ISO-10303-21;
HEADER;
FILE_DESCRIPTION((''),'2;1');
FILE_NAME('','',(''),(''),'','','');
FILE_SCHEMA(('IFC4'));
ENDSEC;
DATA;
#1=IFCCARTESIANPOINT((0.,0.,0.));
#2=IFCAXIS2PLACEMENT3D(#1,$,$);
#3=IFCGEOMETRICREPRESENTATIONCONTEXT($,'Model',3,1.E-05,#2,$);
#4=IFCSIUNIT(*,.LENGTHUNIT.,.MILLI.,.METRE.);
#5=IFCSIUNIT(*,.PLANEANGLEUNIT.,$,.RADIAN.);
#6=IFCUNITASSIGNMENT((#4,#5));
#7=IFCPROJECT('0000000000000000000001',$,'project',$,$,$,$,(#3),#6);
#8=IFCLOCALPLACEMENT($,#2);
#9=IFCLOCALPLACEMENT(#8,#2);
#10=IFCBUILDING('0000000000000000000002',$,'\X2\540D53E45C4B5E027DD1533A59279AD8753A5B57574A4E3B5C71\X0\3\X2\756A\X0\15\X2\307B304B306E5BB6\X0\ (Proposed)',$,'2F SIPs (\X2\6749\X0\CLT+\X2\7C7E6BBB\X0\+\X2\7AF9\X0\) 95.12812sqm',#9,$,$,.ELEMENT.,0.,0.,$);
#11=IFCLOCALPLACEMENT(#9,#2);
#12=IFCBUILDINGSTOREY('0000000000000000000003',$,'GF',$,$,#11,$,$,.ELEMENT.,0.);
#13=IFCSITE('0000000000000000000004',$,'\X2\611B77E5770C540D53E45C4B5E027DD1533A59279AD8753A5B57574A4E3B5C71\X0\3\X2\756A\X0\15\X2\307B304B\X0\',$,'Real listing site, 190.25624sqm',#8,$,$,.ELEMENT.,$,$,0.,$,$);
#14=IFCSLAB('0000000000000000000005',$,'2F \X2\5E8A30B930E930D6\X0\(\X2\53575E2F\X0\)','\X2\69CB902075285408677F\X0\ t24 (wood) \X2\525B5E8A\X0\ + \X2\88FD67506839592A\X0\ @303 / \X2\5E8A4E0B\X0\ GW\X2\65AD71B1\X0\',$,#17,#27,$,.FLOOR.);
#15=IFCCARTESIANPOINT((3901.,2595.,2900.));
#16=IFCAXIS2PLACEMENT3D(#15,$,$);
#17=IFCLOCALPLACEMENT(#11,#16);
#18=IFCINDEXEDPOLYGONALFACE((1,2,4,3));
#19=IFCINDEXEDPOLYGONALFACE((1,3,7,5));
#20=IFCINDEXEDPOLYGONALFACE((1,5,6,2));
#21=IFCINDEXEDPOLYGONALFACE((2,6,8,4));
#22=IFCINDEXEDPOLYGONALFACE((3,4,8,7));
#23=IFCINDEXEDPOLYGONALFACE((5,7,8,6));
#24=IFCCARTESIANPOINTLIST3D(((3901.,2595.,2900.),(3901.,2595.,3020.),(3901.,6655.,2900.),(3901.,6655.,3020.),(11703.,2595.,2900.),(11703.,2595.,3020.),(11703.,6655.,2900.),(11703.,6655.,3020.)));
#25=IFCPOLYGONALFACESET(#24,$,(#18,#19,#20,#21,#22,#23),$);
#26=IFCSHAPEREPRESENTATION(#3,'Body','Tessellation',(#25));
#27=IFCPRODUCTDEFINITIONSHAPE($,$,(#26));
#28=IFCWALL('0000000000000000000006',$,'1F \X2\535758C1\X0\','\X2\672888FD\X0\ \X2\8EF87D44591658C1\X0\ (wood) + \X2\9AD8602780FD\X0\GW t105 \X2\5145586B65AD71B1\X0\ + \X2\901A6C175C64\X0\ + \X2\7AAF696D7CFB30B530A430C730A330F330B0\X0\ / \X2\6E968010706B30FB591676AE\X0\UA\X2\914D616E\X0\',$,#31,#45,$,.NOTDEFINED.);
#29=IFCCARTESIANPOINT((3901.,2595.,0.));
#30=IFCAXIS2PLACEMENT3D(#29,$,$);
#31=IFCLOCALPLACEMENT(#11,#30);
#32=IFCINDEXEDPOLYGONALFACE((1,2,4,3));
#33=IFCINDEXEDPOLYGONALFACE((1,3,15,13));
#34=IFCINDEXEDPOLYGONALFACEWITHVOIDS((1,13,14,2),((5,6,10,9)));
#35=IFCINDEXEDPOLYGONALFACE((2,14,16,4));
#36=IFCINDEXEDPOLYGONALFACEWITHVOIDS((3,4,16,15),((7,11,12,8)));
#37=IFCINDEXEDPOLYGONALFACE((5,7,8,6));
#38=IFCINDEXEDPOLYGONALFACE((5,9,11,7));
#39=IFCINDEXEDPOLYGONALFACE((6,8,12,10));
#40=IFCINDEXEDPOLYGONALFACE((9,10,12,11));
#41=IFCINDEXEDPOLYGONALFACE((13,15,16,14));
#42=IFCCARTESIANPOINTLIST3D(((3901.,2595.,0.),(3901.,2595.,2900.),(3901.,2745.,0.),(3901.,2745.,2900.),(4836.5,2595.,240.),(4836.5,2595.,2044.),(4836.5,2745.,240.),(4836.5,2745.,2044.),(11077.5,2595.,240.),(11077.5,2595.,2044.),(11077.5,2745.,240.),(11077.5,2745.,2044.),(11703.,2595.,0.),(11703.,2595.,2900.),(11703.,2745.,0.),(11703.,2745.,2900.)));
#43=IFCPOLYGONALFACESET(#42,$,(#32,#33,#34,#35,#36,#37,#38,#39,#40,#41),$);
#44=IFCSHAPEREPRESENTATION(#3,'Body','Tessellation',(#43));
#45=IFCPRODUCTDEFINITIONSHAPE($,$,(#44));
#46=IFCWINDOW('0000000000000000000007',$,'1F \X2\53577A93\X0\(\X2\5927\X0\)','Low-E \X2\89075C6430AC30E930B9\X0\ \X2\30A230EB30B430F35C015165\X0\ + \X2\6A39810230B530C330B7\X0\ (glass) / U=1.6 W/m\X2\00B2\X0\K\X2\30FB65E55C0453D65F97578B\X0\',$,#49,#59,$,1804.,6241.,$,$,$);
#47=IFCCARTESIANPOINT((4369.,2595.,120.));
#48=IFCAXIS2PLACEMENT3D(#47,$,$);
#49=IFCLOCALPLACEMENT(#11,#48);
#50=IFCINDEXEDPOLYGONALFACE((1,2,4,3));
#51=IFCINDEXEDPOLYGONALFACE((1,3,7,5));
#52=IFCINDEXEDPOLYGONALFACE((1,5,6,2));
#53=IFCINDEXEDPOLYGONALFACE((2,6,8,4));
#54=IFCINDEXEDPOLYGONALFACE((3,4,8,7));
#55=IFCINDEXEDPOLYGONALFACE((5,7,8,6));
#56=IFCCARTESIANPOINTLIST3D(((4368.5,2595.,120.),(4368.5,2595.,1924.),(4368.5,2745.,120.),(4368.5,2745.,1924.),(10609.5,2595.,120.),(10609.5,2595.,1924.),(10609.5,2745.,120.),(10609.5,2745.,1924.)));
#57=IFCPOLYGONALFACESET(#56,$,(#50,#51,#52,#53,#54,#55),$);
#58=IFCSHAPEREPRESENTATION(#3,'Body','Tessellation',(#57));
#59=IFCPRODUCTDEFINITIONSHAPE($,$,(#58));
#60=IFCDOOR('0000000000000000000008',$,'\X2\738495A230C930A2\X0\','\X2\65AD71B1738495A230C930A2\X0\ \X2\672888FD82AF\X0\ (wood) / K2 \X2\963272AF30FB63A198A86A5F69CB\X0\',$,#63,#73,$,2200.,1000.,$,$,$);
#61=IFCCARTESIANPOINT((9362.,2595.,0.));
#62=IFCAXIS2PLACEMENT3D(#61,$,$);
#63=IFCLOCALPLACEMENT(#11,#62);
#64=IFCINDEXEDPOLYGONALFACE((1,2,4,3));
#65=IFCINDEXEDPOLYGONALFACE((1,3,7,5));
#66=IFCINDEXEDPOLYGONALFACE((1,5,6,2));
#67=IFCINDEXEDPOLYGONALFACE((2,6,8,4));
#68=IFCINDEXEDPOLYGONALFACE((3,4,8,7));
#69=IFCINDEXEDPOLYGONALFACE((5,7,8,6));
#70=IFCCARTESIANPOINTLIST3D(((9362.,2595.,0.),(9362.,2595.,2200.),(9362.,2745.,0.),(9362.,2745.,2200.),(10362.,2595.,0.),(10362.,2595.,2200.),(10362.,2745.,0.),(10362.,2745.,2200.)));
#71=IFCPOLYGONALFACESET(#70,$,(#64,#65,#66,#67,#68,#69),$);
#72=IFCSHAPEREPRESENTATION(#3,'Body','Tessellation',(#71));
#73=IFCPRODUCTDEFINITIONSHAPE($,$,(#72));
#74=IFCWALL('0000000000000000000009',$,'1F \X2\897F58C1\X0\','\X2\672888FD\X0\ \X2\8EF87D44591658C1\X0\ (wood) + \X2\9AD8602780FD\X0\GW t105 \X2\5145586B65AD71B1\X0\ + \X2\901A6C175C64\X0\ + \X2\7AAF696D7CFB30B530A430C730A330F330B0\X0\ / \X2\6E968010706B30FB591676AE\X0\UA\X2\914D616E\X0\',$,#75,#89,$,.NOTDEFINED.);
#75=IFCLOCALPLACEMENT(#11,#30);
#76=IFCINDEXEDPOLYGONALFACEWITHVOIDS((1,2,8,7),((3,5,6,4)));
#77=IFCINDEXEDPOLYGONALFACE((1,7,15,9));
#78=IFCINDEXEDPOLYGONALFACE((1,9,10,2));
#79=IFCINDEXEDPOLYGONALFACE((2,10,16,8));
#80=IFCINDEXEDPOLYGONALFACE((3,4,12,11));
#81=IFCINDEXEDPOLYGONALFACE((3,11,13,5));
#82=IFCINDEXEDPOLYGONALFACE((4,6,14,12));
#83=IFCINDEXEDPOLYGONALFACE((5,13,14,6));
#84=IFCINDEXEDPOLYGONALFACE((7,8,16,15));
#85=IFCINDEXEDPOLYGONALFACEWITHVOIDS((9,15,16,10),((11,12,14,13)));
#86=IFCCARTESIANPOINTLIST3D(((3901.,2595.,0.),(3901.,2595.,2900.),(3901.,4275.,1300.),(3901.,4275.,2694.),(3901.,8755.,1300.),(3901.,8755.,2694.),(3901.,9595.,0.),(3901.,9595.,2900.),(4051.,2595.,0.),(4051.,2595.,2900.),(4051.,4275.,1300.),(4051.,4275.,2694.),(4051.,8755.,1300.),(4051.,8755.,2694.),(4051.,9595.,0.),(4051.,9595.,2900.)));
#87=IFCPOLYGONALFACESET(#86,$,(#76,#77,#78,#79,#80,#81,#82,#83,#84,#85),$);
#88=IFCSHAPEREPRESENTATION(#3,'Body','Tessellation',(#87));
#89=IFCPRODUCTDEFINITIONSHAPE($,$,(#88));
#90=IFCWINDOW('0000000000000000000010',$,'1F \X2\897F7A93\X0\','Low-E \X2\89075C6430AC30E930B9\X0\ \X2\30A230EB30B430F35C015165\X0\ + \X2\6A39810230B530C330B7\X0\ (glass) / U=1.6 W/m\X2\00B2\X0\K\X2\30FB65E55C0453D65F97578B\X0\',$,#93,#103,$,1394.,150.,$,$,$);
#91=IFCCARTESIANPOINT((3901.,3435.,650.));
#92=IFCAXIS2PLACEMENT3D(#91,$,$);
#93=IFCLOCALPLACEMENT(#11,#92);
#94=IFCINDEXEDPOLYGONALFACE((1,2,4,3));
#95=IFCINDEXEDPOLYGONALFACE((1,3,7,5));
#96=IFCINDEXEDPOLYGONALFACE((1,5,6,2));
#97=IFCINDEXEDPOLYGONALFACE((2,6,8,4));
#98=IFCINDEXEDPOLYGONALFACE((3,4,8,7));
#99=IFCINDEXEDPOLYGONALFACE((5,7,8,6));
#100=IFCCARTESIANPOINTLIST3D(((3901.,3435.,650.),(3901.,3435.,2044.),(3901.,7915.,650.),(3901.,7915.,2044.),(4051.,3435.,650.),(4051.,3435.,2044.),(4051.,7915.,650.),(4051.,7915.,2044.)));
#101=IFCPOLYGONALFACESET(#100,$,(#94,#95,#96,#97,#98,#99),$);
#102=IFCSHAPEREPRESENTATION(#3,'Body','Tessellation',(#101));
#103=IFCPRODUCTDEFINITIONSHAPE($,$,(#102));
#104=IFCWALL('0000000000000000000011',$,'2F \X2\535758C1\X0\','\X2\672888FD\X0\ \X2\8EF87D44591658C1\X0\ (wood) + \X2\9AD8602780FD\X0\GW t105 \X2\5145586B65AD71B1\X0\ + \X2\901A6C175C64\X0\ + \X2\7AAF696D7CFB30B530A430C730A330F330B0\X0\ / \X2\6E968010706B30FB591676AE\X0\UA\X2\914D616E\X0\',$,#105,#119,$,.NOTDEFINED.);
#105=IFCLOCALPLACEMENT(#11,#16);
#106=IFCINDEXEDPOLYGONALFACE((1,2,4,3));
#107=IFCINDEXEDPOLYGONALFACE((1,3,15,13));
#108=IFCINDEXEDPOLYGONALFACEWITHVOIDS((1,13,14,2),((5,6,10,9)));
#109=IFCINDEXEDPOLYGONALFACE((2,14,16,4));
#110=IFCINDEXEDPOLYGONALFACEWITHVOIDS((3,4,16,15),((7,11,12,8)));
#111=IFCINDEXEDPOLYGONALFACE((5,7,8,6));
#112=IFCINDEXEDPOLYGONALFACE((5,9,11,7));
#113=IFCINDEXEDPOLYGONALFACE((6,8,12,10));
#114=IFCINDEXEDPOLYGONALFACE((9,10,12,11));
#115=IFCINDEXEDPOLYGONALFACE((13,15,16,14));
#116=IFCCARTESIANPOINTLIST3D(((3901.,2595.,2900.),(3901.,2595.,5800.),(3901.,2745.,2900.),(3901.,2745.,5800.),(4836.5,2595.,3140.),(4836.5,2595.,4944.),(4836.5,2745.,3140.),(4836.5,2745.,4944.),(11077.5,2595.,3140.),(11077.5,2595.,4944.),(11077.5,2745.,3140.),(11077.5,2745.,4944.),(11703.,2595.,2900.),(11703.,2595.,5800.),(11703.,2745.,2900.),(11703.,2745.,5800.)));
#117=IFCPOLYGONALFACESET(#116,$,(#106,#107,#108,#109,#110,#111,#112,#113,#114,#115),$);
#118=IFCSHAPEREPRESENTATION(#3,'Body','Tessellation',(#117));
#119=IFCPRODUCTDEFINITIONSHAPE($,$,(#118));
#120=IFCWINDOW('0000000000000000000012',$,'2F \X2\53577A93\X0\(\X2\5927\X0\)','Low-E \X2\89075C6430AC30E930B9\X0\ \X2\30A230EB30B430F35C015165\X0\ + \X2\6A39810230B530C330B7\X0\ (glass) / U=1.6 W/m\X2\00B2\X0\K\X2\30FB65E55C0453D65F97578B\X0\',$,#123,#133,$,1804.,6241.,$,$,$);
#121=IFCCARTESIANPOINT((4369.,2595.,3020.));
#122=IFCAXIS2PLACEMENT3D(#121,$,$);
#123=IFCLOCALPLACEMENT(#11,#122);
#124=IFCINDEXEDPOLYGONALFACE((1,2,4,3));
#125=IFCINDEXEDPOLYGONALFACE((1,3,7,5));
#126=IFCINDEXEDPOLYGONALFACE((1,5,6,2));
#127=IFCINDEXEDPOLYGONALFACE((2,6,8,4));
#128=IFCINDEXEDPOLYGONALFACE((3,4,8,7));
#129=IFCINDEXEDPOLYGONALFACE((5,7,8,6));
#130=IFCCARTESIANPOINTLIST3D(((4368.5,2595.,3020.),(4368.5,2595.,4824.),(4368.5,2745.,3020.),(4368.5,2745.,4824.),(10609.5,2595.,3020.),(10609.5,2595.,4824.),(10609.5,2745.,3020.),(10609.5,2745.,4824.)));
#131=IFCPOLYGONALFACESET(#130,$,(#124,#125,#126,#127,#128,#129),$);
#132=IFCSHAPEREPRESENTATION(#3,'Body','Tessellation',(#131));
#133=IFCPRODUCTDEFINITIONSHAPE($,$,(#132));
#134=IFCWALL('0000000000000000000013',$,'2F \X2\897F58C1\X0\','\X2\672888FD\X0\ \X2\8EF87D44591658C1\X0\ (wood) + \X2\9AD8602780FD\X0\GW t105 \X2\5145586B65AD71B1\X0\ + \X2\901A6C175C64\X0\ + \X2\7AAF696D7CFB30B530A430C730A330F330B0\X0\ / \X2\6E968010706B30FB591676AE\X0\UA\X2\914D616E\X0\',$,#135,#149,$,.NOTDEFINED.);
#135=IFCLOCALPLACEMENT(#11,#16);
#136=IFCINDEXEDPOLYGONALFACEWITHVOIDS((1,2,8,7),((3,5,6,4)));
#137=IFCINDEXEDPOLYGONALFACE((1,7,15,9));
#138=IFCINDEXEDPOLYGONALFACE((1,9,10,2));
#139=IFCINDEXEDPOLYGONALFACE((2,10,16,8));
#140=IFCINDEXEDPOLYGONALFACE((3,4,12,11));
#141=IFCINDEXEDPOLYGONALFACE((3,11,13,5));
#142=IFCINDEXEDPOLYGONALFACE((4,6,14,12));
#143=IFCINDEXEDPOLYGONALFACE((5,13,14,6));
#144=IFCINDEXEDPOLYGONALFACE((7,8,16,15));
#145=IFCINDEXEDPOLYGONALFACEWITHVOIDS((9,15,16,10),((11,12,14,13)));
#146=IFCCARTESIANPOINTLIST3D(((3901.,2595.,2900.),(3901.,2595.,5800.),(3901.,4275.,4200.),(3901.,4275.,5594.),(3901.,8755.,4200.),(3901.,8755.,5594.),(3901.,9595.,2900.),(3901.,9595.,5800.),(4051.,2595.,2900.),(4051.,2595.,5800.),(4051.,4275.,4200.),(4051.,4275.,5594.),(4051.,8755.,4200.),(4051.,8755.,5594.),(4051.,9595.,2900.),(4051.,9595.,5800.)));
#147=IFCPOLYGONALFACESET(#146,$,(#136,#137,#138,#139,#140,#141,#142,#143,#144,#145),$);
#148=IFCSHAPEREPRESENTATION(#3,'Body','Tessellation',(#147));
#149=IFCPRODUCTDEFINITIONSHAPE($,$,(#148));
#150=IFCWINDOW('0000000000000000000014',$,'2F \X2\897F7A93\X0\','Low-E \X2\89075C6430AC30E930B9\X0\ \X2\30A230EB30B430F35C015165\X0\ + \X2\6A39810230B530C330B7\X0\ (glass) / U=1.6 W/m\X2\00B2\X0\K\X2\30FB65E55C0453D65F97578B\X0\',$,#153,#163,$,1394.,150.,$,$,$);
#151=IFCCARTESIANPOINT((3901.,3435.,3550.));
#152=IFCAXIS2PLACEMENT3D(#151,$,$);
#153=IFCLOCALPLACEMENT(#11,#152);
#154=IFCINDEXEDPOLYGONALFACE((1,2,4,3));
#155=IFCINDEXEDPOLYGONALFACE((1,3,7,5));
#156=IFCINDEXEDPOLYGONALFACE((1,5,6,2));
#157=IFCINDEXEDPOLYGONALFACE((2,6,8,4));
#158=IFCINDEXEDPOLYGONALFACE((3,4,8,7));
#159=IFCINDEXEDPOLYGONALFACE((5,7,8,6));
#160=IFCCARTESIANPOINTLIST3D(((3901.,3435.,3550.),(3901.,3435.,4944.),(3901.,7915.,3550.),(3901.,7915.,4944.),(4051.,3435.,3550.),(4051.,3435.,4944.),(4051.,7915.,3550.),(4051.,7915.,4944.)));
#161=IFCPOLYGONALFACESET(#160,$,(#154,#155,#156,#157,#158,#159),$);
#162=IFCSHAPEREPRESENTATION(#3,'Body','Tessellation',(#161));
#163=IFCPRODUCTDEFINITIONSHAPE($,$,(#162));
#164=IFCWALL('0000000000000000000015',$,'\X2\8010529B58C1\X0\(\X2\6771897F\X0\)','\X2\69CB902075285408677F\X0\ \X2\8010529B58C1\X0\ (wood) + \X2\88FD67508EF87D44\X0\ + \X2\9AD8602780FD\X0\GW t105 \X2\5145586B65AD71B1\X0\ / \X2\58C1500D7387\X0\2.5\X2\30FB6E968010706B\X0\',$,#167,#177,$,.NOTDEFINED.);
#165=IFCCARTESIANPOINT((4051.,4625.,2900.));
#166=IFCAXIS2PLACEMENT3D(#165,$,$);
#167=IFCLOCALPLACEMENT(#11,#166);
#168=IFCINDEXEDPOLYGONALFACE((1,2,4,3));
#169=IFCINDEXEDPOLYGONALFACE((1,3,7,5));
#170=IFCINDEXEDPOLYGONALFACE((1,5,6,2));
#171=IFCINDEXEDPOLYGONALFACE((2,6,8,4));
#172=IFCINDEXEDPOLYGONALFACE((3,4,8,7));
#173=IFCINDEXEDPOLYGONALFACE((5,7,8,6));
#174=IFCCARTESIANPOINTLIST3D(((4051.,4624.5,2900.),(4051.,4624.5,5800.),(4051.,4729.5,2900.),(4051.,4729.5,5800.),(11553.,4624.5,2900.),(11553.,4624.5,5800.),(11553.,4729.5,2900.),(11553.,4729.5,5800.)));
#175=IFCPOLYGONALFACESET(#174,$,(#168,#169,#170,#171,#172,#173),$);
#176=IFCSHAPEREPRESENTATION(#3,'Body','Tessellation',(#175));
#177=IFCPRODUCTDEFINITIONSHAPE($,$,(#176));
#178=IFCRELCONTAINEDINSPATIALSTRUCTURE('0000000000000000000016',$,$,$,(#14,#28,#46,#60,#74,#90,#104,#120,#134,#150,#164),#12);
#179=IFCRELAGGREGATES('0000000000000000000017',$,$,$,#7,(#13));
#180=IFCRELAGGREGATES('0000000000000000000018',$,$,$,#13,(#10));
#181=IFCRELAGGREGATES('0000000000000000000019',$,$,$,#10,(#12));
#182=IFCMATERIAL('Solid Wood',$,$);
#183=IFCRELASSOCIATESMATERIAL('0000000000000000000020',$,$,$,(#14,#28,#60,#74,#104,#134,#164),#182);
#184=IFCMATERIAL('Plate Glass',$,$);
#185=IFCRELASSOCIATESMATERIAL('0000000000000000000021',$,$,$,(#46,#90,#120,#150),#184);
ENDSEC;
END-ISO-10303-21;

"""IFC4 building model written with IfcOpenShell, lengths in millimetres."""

from ifc_helpers import new_model, si_unit, frame, frame_2d, origin, place, context, project, spatial, rectangle, extrude, material, element, fill, save


model = new_model("IFC4")

# Units and contexts
model_context = context("Model", 3, precision=1e-05, world=origin())
ifc_project = project(units=[si_unit("LENGTHUNIT", "METRE", prefix="MILLI"), si_unit("PLANEANGLEUNIT", "RADIAN")], contexts=[model_context])

# Site, building, storey
site_placement = place(None, origin())
site = spatial("IfcSite", under=ifc_project, at=site_placement, Name="愛知県名古屋市緑区大高町字坊主山3番15ほか", ObjectType="Real listing site, 190.25624sqm", CompositionType="ELEMENT", RefElevation=0.0)
building_placement = place(site_placement, origin())
building = spatial("IfcBuilding", under=site, at=building_placement, Name="名古屋市緑区大高町字坊主山3番15ほかの家 (Proposed)", ObjectType="2F SIPs (杉CLT+籾殻+竹) 95.12812sqm", CompositionType="ELEMENT", ElevationOfRefHeight=0.0, ElevationOfTerrain=0.0)
storey_placement = place(building_placement, origin())
storey = spatial("IfcBuildingStorey", under=building, at=storey_placement, Name="GF", CompositionType="ELEMENT", Elevation=0.0)

# Slab
ifc_material_1 = material(Name="Solid Wood")
slab_1_placement = place(storey_placement, frame((3901.0, 2595.0, 2900.0)))
element("IfcSlab", 1, at=slab_1_placement, inside=storey, material=ifc_material_1, Name="2F 床スラブ(南帯)", Description="構造用合板 t24 (wood) 剛床 + 製材根太 @303 / 床下 GW断熱", PredefinedType="FLOOR", context=model_context, shape_type="SweptSolid", body=[
    extrude(rectangle(XDim=7802.0, YDim=4060.0, at=frame_2d((3901.0, 2030.0))), frame((3901.0, 2595.0, 2900.0)), (0.0, 0.0, 1.0), 120.0),
])

# Wall, openings, window, door
wall_1_placement = place(storey_placement, frame((3901.0, 2595.0, 0.0)))
wall_1 = element("IfcWall", 2, at=wall_1_placement, inside=storey, material=ifc_material_1, Name="1F 南壁", Description="木製 軸組外壁 (wood) + 高性能GW t105 充填断熱 + 通気層 + 窯業系サイディング / 準耐火・外皮UA配慮", PredefinedType="NOTDEFINED", context=model_context, shape_type="SweptSolid", body=[
    extrude(rectangle(XDim=7802.0, YDim=150.0, at=frame_2d((3901.0, 75.0))), frame((3901.0, 2595.0, 0.0)), (0.0, 0.0, 1.0), 2900.0),
])
opening_1_placement = place(storey_placement, frame((4369.0, 2595.0, 120.0)))
opening_1 = element("IfcOpeningElement", 3, at=opening_1_placement, cuts=wall_1, PredefinedType="NOTDEFINED", context=model_context, shape_type="SweptSolid", body=[
    extrude(rectangle(XDim=6241.0, YDim=150.0, at=frame_2d((3120.0, 75.0))), frame((4369.0, 2595.0, 120.0)), (0.0, 0.0, 1.0), 1804.0),
])
opening_2_placement = place(storey_placement, frame((9362.0, 2595.0, 0.0)))
opening_2 = element("IfcOpeningElement", 4, at=opening_2_placement, cuts=wall_1, PredefinedType="NOTDEFINED", context=model_context, shape_type="SweptSolid", body=[
    extrude(rectangle(XDim=1000.0, YDim=150.0, at=frame_2d((500.0, 75.0))), frame((9362.0, 2595.0, 0.0)), (0.0, 0.0, 1.0), 2200.0),
])
ifc_material_2 = material(Name="Plate Glass")
window_1_placement = place(storey_placement, frame((4369.0, 2595.0, 120.0)))
window_1 = element("IfcWindow", 5, at=window_1_placement, inside=storey, material=ifc_material_2, Name="1F 南窓(大)", Description="Low-E 複層ガラス アルゴン封入 + 樹脂サッシ (glass) / U=1.6 W/m²K・日射取得型", OverallHeight=1804.0, OverallWidth=6241.0, context=model_context, shape_type="SweptSolid", body=[
    extrude(rectangle(XDim=6241.0, YDim=150.0, at=frame_2d((3120.0, 75.0))), frame((4369.0, 2595.0, 120.0)), (0.0, 0.0, 1.0), 1804.0),
])
fill(opening_1, window_1)
door_placement = place(storey_placement, frame((9362.0, 2595.0, 0.0)))
door = element("IfcDoor", 6, at=door_placement, inside=storey, material=ifc_material_1, Name="玄関ドア", Description="断熱玄関ドア 木製芯 (wood) / K2 防犯・採風機構", OverallHeight=2200.0, OverallWidth=1000.0, context=model_context, shape_type="SweptSolid", body=[
    extrude(rectangle(XDim=1000.0, YDim=150.0, at=frame_2d((500.0, 75.0))), frame((9362.0, 2595.0, 0.0)), (0.0, 0.0, 1.0), 2200.0),
])
fill(opening_2, door)

# Wall, opening, window
wall_2_placement = place(storey_placement, frame((3901.0, 2595.0, 0.0)))
wall_2 = element("IfcWall", 7, at=wall_2_placement, inside=storey, material=ifc_material_1, Name="1F 西壁", Description="木製 軸組外壁 (wood) + 高性能GW t105 充填断熱 + 通気層 + 窯業系サイディング / 準耐火・外皮UA配慮", PredefinedType="NOTDEFINED", context=model_context, shape_type="SweptSolid", body=[
    extrude(rectangle(XDim=150.0, YDim=7000.0, at=frame_2d((75.0, 3500.0))), frame((3901.0, 2595.0, 0.0)), (0.0, 0.0, 1.0), 2900.0),
])
opening_3_placement = place(storey_placement, frame((3901.0, 3435.0, 650.0)))
opening_3 = element("IfcOpeningElement", 8, at=opening_3_placement, cuts=wall_2, PredefinedType="NOTDEFINED", context=model_context, shape_type="SweptSolid", body=[
    extrude(rectangle(XDim=150.0, YDim=4480.0, at=frame_2d((75.0, 2240.0))), frame((3901.0, 3435.0, 650.0)), (0.0, 0.0, 1.0), 1394.0),
])
window_2_placement = place(storey_placement, frame((3901.0, 3435.0, 650.0)))
window_2 = element("IfcWindow", 9, at=window_2_placement, inside=storey, material=ifc_material_2, Name="1F 西窓", Description="Low-E 複層ガラス アルゴン封入 + 樹脂サッシ (glass) / U=1.6 W/m²K・日射取得型", OverallHeight=1394.0, OverallWidth=150.0, context=model_context, shape_type="SweptSolid", body=[
    extrude(rectangle(XDim=150.0, YDim=4480.0, at=frame_2d((75.0, 2240.0))), frame((3901.0, 3435.0, 650.0)), (0.0, 0.0, 1.0), 1394.0),
])
fill(opening_3, window_2)

# Walls, openings, windows
wall_3_placement = place(storey_placement, frame((3901.0, 2595.0, 2900.0)))
wall_3 = element("IfcWall", 10, at=wall_3_placement, inside=storey, material=ifc_material_1, Name="2F 南壁", Description="木製 軸組外壁 (wood) + 高性能GW t105 充填断熱 + 通気層 + 窯業系サイディング / 準耐火・外皮UA配慮", PredefinedType="NOTDEFINED", context=model_context, shape_type="SweptSolid", body=[
    extrude(rectangle(XDim=7802.0, YDim=150.0, at=frame_2d((3901.0, 75.0))), frame((3901.0, 2595.0, 2900.0)), (0.0, 0.0, 1.0), 2900.0),
])
opening_4_placement = place(storey_placement, frame((4369.0, 2595.0, 3020.0)))
opening_4 = element("IfcOpeningElement", 11, at=opening_4_placement, cuts=wall_3, PredefinedType="NOTDEFINED", context=model_context, shape_type="SweptSolid", body=[
    extrude(rectangle(XDim=6241.0, YDim=150.0, at=frame_2d((3120.0, 75.0))), frame((4369.0, 2595.0, 3020.0)), (0.0, 0.0, 1.0), 1804.0),
])
window_3_placement = place(storey_placement, frame((4369.0, 2595.0, 3020.0)))
window_3 = element("IfcWindow", 12, at=window_3_placement, inside=storey, material=ifc_material_2, Name="2F 南窓(大)", Description="Low-E 複層ガラス アルゴン封入 + 樹脂サッシ (glass) / U=1.6 W/m²K・日射取得型", OverallHeight=1804.0, OverallWidth=6241.0, context=model_context, shape_type="SweptSolid", body=[
    extrude(rectangle(XDim=6241.0, YDim=150.0, at=frame_2d((3120.0, 75.0))), frame((4369.0, 2595.0, 3020.0)), (0.0, 0.0, 1.0), 1804.0),
])
fill(opening_4, window_3)
wall_4_placement = place(storey_placement, frame((3901.0, 2595.0, 2900.0)))
wall_4 = element("IfcWall", 13, at=wall_4_placement, inside=storey, material=ifc_material_1, Name="2F 西壁", Description="木製 軸組外壁 (wood) + 高性能GW t105 充填断熱 + 通気層 + 窯業系サイディング / 準耐火・外皮UA配慮", PredefinedType="NOTDEFINED", context=model_context, shape_type="SweptSolid", body=[
    extrude(rectangle(XDim=150.0, YDim=7000.0, at=frame_2d((75.0, 3500.0))), frame((3901.0, 2595.0, 2900.0)), (0.0, 0.0, 1.0), 2900.0),
])
opening_5_placement = place(storey_placement, frame((3901.0, 3435.0, 3550.0)))
opening_5 = element("IfcOpeningElement", 14, at=opening_5_placement, cuts=wall_4, PredefinedType="NOTDEFINED", context=model_context, shape_type="SweptSolid", body=[
    extrude(rectangle(XDim=150.0, YDim=4480.0, at=frame_2d((75.0, 2240.0))), frame((3901.0, 3435.0, 3550.0)), (0.0, 0.0, 1.0), 1394.0),
])
window_4_placement = place(storey_placement, frame((3901.0, 3435.0, 3550.0)))
window_4 = element("IfcWindow", 15, at=window_4_placement, inside=storey, material=ifc_material_2, Name="2F 西窓", Description="Low-E 複層ガラス アルゴン封入 + 樹脂サッシ (glass) / U=1.6 W/m²K・日射取得型", OverallHeight=1394.0, OverallWidth=150.0, context=model_context, shape_type="SweptSolid", body=[
    extrude(rectangle(XDim=150.0, YDim=4480.0, at=frame_2d((75.0, 2240.0))), frame((3901.0, 3435.0, 3550.0)), (0.0, 0.0, 1.0), 1394.0),
])
fill(opening_5, window_4)

# Wall
wall_5_placement = place(storey_placement, frame((4051.0, 4625.0, 2900.0)))
element("IfcWall", 16, at=wall_5_placement, inside=storey, material=ifc_material_1, Name="耐力壁(東西)", Description="構造用合板 耐力壁 (wood) + 製材軸組 + 高性能GW t105 充填断熱 / 壁倍率2.5・準耐火", PredefinedType="NOTDEFINED", context=model_context, shape_type="SweptSolid", body=[
    extrude(rectangle(XDim=7502.0, YDim=105.0, at=frame_2d((3751.0, 52.0))), frame((4051.0, 4625.0, 2900.0)), (0.0, 0.0, 1.0), 2900.0),
])

save(model, "model.ifc")
